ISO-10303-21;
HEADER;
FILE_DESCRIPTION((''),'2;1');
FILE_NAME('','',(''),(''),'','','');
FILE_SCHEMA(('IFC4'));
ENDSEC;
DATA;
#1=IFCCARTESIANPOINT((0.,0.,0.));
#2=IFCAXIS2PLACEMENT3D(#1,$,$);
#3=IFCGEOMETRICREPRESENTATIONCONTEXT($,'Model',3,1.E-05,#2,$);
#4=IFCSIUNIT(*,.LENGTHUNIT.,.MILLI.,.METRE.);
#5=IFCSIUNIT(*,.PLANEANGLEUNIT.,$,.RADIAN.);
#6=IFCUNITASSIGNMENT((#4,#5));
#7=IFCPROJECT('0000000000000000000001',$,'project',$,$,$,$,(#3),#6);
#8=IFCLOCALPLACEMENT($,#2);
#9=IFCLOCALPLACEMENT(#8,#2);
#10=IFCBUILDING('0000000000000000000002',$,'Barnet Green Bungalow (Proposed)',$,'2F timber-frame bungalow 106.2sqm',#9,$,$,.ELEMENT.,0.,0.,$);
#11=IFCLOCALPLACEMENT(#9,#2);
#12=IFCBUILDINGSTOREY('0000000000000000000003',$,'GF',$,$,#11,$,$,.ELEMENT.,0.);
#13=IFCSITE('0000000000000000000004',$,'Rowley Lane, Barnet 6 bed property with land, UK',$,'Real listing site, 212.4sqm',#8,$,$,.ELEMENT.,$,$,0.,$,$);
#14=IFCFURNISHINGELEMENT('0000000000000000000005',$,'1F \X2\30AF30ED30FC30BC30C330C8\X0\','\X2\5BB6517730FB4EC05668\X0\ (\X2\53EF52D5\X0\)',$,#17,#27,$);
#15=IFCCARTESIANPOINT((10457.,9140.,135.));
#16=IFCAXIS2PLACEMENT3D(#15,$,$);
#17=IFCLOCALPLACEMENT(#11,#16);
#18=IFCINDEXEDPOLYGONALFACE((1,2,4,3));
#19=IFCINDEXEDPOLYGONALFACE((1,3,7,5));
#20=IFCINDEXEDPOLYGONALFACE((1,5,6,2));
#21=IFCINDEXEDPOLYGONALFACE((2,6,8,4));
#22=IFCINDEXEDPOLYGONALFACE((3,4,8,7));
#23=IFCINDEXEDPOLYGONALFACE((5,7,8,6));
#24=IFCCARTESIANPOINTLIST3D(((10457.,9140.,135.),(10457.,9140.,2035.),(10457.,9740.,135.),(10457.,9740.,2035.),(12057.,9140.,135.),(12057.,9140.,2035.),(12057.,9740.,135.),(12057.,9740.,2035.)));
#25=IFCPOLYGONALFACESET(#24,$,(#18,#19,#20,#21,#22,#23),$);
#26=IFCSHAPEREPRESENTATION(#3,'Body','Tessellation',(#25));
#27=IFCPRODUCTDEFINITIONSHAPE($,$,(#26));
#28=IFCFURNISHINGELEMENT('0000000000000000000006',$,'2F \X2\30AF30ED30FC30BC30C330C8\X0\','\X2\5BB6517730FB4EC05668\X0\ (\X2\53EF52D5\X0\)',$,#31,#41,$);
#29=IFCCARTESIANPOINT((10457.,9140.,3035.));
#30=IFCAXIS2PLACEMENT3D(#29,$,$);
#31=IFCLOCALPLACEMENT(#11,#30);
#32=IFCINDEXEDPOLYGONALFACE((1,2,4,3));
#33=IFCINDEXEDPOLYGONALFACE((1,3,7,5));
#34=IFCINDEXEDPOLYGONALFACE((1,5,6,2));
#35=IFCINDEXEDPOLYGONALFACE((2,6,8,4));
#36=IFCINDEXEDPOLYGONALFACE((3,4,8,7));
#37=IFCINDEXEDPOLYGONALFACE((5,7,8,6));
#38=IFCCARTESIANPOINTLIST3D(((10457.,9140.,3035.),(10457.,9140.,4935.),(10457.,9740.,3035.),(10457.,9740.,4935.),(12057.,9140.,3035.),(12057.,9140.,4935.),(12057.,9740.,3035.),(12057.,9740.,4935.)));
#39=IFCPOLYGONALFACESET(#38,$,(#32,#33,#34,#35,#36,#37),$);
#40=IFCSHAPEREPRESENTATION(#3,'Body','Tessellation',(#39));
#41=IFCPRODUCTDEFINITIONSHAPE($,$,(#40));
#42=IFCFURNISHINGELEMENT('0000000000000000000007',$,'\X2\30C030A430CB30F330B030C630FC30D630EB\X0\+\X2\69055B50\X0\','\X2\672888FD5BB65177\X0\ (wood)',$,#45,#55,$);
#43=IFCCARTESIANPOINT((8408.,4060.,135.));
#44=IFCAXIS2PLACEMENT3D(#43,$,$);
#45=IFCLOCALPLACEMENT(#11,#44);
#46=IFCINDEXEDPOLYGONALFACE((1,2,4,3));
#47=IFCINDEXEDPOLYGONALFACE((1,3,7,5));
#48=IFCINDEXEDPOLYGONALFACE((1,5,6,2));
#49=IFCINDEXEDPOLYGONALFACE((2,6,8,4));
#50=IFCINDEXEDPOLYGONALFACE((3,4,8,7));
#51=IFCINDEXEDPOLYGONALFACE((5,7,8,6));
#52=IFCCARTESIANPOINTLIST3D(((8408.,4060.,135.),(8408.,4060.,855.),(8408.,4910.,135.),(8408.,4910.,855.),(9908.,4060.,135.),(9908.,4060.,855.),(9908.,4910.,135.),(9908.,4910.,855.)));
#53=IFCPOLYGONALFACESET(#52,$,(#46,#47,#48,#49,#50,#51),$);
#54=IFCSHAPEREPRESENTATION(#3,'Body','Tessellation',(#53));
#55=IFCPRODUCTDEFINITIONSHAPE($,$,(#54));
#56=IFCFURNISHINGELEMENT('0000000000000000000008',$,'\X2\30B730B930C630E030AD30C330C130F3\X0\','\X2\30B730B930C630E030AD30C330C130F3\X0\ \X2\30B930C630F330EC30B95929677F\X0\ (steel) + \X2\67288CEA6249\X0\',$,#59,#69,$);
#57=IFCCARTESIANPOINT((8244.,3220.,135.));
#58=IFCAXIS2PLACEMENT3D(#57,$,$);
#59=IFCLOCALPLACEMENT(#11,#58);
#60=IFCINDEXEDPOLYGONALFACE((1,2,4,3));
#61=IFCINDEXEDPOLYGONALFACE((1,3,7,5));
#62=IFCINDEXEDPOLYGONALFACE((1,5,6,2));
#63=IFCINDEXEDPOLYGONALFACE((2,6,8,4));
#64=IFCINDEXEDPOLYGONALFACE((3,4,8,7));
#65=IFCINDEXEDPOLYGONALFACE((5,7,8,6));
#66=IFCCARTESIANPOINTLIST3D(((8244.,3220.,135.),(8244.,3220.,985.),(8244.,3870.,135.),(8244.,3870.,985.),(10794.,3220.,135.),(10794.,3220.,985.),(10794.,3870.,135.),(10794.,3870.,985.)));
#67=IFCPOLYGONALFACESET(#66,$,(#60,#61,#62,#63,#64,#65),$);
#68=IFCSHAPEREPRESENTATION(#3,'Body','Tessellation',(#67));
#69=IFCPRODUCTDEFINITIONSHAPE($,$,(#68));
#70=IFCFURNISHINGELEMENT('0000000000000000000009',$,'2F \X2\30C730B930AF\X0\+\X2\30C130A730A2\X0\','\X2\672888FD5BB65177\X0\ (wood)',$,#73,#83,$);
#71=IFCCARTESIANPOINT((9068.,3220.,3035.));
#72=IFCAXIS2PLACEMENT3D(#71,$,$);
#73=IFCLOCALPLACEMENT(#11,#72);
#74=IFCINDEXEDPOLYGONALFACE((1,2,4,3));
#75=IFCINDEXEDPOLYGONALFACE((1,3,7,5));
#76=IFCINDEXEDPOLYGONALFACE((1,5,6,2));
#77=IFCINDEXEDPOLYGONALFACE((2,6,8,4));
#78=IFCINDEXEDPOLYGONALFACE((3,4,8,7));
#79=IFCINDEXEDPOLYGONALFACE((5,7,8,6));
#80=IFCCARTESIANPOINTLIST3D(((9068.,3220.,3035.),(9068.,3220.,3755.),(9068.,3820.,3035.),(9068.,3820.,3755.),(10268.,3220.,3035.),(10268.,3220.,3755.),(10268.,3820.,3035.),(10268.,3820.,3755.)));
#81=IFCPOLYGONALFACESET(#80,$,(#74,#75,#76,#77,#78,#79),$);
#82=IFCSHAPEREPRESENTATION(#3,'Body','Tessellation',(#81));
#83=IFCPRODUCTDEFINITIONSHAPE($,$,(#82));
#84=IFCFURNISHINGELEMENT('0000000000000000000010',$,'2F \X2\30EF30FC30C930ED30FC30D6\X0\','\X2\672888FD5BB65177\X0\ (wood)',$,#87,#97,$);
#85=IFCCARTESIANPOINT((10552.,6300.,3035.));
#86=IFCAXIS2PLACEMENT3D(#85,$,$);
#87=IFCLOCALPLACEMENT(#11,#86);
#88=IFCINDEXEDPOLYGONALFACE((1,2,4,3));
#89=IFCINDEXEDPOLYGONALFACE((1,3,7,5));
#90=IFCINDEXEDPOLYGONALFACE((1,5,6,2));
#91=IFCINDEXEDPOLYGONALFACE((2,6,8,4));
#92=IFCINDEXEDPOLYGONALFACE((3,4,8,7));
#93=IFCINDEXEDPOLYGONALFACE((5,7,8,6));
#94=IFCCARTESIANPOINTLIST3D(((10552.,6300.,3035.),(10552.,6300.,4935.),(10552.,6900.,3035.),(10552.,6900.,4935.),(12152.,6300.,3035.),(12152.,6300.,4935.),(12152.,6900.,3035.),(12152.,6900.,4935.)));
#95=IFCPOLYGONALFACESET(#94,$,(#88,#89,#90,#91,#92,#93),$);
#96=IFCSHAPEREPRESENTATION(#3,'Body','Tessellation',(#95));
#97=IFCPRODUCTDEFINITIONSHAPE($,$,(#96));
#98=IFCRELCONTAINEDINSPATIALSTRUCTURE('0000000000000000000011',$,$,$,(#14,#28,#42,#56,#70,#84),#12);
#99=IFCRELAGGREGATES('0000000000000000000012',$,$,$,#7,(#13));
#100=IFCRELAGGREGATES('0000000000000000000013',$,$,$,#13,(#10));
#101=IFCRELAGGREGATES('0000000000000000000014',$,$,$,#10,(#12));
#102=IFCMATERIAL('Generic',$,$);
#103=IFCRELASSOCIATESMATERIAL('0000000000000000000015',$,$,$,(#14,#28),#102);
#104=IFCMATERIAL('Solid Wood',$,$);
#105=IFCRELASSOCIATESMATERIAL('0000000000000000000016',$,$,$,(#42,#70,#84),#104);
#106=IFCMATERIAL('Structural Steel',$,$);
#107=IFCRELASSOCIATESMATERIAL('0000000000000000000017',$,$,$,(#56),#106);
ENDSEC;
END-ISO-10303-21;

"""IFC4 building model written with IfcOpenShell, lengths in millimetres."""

from ifc_helpers import new_model, si_unit, frame, frame_2d, origin, place, context, project, spatial, rectangle, extrude, material, element, save


model = new_model("IFC4")

# Units and contexts
model_context = context("Model", 3, precision=1e-05, world=origin())
ifc_project = project(units=[si_unit("LENGTHUNIT", "METRE", prefix="MILLI"), si_unit("PLANEANGLEUNIT", "RADIAN")], contexts=[model_context])

# Site, building, storey
site_placement = place(None, origin())
site = spatial("IfcSite", under=ifc_project, at=site_placement, Name="Rowley Lane, Barnet 6 bed property with land, UK", ObjectType="Real listing site, 212.4sqm", CompositionType="ELEMENT", RefElevation=0.0)
building_placement = place(site_placement, origin())
building = spatial("IfcBuilding", under=site, at=building_placement, Name="Barnet Green Bungalow (Proposed)", ObjectType="2F timber-frame bungalow 106.2sqm", CompositionType="ELEMENT", ElevationOfRefHeight=0.0, ElevationOfTerrain=0.0)
storey_placement = place(building_placement, origin())
storey = spatial("IfcBuildingStorey", under=building, at=storey_placement, Name="GF", CompositionType="ELEMENT", Elevation=0.0)

# Shared definitions
ifc_material_1 = material(Name="Solid Wood")

# Shared definitions
ifc_material_2 = material(Name="Generic")

# Furnishing elements
furnishing_1_placement = place(storey_placement, frame((10457.0, 9140.0, 135.0)))
element("IfcFurnishingElement", 1, at=furnishing_1_placement, inside=storey, material=ifc_material_2, Name="1F クローゼット", Description="家具・什器 (可動)", context=model_context, shape_type="SweptSolid", body=[
    extrude(rectangle(XDim=1600.0, YDim=600.0, at=frame_2d((800.0, 300.0))), frame((10457.0, 9140.0, 135.0)), (0.0, 0.0, 1.0), 1900.0),
])
furnishing_2_placement = place(storey_placement, frame((10457.0, 9140.0, 3035.0)))
element("IfcFurnishingElement", 2, at=furnishing_2_placement, inside=storey, material=ifc_material_2, Name="2F クローゼット", Description="家具・什器 (可動)", context=model_context, shape_type="SweptSolid", body=[
    extrude(rectangle(XDim=1600.0, YDim=600.0, at=frame_2d((800.0, 300.0))), frame((10457.0, 9140.0, 3035.0)), (0.0, 0.0, 1.0), 1900.0),
])
furnishing_3_placement = place(storey_placement, frame((8408.0, 4060.0, 135.0)))
element("IfcFurnishingElement", 3, at=furnishing_3_placement, inside=storey, material=ifc_material_1, Name="ダイニングテーブル+椅子", Description="木製家具 (wood)", context=model_context, shape_type="SweptSolid", body=[
    extrude(rectangle(XDim=1500.0, YDim=850.0, at=frame_2d((750.0, 425.0))), frame((8408.0, 4060.0, 135.0)), (0.0, 0.0, 1.0), 720.0),
])
ifc_material_3 = material(Name="Structural Steel")
furnishing_4_placement = place(storey_placement, frame((8244.0, 3220.0, 135.0)))
element("IfcFurnishingElement", 4, at=furnishing_4_placement, inside=storey, material=ifc_material_3, Name="システムキッチン", Description="システムキッチン ステンレス天板 (steel) + 木質扉", context=model_context, shape_type="SweptSolid", body=[
    extrude(rectangle(XDim=2550.0, YDim=650.0, at=frame_2d((1275.0, 325.0))), frame((8244.0, 3220.0, 135.0)), (0.0, 0.0, 1.0), 850.0),
])
furnishing_5_placement = place(storey_placement, frame((9068.0, 3220.0, 3035.0)))
element("IfcFurnishingElement", 5, at=furnishing_5_placement, inside=storey, material=ifc_material_1, Name="2F デスク+チェア", Description="木製家具 (wood)", context=model_context, shape_type="SweptSolid", body=[
    extrude(rectangle(XDim=1200.0, YDim=600.0, at=frame_2d((600.0, 300.0))), frame((9068.0, 3220.0, 3035.0)), (0.0, 0.0, 1.0), 720.0),
])
furnishing_6_placement = place(storey_placement, frame((10552.0, 6300.0, 3035.0)))
element("IfcFurnishingElement", 6, at=furnishing_6_placement, inside=storey, material=ifc_material_1, Name="2F ワードローブ", Description="木製家具 (wood)", context=model_context, shape_type="SweptSolid", body=[
    extrude(rectangle(XDim=1600.0, YDim=600.0, at=frame_2d((800.0, 300.0))), frame((10552.0, 6300.0, 3035.0)), (0.0, 0.0, 1.0), 1900.0),
])

save(model, "model.ifc")
